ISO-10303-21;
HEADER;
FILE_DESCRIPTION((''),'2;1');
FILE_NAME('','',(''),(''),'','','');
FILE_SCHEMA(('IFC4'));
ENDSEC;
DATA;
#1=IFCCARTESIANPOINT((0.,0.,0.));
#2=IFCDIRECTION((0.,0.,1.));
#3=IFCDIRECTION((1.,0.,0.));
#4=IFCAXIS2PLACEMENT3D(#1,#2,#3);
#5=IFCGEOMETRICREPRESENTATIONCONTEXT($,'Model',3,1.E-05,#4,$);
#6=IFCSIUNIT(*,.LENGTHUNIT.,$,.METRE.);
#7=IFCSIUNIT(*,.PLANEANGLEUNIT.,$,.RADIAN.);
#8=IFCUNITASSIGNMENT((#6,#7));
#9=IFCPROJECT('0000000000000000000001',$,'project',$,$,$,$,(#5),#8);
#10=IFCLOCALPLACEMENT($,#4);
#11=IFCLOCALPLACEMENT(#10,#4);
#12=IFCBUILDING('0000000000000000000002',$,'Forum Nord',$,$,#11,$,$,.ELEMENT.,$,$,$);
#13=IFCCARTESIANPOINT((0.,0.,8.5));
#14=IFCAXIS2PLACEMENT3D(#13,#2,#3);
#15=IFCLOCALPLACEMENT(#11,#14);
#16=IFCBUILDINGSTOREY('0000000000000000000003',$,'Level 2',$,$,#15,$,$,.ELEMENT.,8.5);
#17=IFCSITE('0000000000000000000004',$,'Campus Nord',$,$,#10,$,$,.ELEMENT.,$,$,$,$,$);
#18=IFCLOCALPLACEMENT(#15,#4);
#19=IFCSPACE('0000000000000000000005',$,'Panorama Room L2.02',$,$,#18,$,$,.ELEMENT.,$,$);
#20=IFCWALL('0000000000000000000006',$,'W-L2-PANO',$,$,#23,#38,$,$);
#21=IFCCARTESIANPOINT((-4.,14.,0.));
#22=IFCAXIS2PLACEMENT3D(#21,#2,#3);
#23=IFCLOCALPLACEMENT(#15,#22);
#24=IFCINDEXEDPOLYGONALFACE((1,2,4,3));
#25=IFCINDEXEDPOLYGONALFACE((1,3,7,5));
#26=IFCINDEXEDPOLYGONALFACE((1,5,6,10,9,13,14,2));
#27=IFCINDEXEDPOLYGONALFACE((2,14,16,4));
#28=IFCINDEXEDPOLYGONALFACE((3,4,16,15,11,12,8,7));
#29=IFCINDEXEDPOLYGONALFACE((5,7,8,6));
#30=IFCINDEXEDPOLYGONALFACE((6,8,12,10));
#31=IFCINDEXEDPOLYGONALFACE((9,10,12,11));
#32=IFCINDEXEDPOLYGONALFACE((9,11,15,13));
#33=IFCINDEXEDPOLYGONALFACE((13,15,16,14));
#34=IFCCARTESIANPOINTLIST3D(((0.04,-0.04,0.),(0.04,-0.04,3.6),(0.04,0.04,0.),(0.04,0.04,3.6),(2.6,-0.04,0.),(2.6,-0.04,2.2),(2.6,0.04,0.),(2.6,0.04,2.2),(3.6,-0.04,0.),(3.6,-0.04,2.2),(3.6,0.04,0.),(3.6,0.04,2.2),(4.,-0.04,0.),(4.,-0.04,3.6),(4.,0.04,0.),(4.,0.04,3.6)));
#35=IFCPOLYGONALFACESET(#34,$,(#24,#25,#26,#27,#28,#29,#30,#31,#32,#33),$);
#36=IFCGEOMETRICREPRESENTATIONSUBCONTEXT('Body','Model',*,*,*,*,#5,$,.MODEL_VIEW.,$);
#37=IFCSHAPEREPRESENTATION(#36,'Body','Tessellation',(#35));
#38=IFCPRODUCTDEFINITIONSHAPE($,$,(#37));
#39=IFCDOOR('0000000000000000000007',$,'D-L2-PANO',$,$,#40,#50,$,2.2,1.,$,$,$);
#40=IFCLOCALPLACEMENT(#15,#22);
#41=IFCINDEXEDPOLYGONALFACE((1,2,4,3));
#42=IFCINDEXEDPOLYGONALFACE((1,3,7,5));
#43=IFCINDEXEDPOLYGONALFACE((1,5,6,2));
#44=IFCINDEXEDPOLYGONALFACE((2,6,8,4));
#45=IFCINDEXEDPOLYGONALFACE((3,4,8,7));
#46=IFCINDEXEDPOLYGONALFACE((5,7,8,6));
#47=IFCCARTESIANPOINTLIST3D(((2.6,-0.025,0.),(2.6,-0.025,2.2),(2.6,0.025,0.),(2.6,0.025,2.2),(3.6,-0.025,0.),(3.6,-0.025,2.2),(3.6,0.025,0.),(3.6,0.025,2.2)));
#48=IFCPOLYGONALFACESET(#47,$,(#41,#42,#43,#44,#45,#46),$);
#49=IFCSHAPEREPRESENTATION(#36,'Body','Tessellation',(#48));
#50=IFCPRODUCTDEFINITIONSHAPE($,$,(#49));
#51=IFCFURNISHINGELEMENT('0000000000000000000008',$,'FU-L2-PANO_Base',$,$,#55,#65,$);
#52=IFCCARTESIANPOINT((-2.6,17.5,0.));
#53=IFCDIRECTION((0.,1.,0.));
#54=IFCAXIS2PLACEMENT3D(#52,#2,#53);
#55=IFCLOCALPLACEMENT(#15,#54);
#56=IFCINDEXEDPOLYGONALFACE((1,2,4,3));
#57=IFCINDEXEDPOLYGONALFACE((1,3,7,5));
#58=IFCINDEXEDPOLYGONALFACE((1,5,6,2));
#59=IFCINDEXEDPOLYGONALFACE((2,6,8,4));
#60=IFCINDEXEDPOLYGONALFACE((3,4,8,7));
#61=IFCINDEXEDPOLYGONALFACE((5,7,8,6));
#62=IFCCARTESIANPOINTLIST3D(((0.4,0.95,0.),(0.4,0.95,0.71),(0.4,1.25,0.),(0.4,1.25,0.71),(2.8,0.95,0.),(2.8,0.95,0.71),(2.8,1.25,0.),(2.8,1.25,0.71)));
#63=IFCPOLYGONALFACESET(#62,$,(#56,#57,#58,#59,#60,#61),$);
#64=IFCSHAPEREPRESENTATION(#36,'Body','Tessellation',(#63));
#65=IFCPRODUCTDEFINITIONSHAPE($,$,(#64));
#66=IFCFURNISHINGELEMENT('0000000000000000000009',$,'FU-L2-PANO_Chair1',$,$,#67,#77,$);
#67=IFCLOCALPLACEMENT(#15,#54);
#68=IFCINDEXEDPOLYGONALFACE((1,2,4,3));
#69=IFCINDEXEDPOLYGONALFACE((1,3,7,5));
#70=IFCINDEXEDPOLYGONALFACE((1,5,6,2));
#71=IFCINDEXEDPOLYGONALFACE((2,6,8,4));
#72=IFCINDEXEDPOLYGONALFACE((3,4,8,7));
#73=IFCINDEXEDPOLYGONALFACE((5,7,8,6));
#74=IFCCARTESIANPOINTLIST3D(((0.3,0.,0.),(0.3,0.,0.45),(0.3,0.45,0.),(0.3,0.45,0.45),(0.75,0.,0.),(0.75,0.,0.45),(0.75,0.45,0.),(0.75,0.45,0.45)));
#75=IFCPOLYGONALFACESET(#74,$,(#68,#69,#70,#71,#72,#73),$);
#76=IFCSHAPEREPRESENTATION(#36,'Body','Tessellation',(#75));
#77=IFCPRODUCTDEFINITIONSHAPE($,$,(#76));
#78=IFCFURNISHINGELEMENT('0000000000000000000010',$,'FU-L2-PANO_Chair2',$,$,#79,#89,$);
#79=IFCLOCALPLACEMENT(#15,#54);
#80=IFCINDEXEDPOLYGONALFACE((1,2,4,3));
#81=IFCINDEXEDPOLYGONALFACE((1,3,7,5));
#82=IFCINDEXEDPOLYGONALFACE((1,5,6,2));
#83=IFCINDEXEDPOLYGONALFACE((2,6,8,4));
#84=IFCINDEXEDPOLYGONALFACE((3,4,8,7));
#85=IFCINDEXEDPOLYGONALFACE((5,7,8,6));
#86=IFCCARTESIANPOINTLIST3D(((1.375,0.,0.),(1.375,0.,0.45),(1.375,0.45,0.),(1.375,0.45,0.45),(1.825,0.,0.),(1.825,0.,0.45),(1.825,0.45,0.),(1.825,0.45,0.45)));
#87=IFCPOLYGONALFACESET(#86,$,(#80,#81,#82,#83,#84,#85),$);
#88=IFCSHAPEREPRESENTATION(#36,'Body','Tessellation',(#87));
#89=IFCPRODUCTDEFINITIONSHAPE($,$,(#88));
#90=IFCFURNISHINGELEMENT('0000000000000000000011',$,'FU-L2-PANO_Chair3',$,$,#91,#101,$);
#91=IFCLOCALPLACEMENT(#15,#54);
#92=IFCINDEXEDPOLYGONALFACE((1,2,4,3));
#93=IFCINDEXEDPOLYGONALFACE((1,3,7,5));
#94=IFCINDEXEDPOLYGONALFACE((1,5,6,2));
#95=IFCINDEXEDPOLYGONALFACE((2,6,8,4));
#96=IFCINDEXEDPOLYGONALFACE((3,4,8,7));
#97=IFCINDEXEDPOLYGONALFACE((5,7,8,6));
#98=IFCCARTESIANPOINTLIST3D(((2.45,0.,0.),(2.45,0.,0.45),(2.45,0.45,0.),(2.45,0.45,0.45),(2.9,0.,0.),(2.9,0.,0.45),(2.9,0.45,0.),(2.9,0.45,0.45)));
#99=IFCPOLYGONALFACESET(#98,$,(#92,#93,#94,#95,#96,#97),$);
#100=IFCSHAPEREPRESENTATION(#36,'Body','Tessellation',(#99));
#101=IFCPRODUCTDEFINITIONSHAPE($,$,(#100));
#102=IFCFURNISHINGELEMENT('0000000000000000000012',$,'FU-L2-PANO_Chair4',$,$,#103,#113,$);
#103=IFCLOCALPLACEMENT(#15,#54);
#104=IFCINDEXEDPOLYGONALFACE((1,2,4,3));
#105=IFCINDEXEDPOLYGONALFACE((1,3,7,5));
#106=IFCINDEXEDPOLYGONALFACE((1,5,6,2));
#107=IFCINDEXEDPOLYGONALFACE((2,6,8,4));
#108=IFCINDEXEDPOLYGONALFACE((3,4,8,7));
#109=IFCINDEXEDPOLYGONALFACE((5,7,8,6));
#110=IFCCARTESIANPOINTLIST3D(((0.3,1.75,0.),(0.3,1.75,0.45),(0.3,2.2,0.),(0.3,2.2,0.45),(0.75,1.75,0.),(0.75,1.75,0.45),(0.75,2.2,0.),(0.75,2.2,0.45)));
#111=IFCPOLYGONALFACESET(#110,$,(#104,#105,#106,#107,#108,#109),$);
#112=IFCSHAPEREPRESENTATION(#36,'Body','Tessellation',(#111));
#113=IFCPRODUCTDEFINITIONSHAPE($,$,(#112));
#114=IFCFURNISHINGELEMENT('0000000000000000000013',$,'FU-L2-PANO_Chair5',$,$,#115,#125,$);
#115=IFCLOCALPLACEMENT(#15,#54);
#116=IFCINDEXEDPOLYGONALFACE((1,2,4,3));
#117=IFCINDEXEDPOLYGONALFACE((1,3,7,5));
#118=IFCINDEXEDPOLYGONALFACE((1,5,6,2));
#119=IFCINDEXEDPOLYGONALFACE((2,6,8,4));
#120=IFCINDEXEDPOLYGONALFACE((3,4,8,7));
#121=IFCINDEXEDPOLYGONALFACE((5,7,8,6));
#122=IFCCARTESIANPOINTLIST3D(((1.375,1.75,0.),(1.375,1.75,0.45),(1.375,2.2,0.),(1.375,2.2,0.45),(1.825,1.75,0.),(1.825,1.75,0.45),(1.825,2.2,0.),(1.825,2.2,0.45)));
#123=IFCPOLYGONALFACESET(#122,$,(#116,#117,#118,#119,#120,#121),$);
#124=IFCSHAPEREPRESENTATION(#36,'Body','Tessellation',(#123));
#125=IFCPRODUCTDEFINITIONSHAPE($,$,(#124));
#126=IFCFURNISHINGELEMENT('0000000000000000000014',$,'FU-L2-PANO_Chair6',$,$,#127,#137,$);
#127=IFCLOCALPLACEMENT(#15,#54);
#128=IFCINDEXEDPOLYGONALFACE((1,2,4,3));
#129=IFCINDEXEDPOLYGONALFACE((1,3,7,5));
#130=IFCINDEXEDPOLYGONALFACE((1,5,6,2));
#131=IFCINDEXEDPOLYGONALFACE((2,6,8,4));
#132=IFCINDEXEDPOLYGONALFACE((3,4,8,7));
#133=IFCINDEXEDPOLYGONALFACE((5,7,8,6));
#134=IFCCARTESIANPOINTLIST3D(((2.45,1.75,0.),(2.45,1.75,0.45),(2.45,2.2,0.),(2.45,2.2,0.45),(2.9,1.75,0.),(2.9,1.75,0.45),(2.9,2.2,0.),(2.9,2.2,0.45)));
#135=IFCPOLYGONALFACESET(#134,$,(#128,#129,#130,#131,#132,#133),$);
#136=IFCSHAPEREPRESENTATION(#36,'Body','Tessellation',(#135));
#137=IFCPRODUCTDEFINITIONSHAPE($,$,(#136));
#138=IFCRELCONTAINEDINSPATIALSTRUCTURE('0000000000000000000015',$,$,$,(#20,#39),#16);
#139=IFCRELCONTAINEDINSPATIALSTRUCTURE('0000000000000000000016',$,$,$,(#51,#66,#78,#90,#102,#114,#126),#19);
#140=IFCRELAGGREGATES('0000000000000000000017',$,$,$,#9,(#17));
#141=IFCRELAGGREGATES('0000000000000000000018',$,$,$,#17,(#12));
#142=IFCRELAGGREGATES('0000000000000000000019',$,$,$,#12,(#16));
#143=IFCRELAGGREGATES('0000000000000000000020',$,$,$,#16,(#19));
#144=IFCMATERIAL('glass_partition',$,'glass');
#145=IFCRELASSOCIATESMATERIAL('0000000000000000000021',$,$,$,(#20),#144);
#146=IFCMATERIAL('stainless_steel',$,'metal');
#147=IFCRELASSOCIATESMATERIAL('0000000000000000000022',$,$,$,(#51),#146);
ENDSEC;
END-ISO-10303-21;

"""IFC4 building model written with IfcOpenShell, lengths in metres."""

from ifc_helpers import new_model, si_unit, frame, frame_2d, origin_with_axes, place, context, subcontext, project, spatial, polyline, rectangle, outline, extrude, material, element, fill, save


model = new_model("IFC4")

# Units and contexts
model_context = context("Model", 3, precision=1e-05, world=origin_with_axes())
body_context = subcontext(model_context, "Body", "Model", "MODEL_VIEW")
ifc_project = project(units=[si_unit("LENGTHUNIT", "METRE"), si_unit("PLANEANGLEUNIT", "RADIAN")], contexts=[model_context])

# Site, building, storey
site_placement = place(None, origin_with_axes())
site = spatial("IfcSite", under=ifc_project, at=site_placement, Name="Campus Nord", CompositionType="ELEMENT")
building_placement = place(site_placement, origin_with_axes())
building = spatial("IfcBuilding", under=site, at=building_placement, Name="Forum Nord", CompositionType="ELEMENT")
storey_placement = place(building_placement, frame((0.0, 0.0, 8.5), z_axis=(0.0, 0.0, 1.0), x_axis=(1.0, 0.0, 0.0)))
storey = spatial("IfcBuildingStorey", under=building, at=storey_placement, Name="Level 2", CompositionType="ELEMENT", Elevation=8.5)

# Wall, opening, door
ifc_material_1 = material(Name="glass_partition", Category="glass")
wall_1_placement = place(storey_placement, frame((-4.0, 14.0, 0.0), z_axis=(0.0, 0.0, 1.0), x_axis=(1.0, 0.0, 0.0)))
wall_1 = element("IfcWall", 1, at=wall_1_placement, inside=storey, material=ifc_material_1, Name="W-L2-PANO", context=body_context, shape_type="SweptSolid", body=[
    extrude(outline(polyline([(0.04, -0.04), (4.0, -0.04), (4.0, 0.04), (0.04, 0.04), (0.04, -0.04)])), origin_with_axes(), (0.0, 0.0, 1.0), 3.6),
])
opening_placement = place(storey_placement, frame((-4.0, 14.0, 0.0), z_axis=(0.0, 0.0, 1.0), x_axis=(1.0, 0.0, 0.0)))
opening = element("IfcOpeningElement", 2, at=opening_placement, cuts=wall_1, context=body_context, shape_type="SweptSolid", body=[
    extrude(rectangle(XDim=1.0, YDim=0.08, at=frame_2d((3.1, 0.0), x_axis=(1.0, 0.0))), origin_with_axes(), (0.0, 0.0, 1.0), 2.2),
])
door_placement = place(storey_placement, frame((-4.0, 14.0, 0.0), z_axis=(0.0, 0.0, 1.0), x_axis=(1.0, 0.0, 0.0)))
door = element("IfcDoor", 3, at=door_placement, inside=storey, Name="D-L2-PANO", OverallHeight=2.2, OverallWidth=1.0, context=body_context, shape_type="SweptSolid", body=[
    extrude(rectangle(XDim=1.0, YDim=0.05, at=frame_2d((3.1, 0.0), x_axis=(1.0, 0.0))), origin_with_axes(), (0.0, 0.0, 1.0), 2.2),
])
fill(opening, door)

# Shared definitions
space_placement = place(storey_placement, origin_with_axes())
space = spatial("IfcSpace", under=storey, at=space_placement, Name="Panorama Room L2.02", CompositionType="ELEMENT")

# Furnishing elements
ifc_material_2 = material(Name="stainless_steel", Category="metal")
furnishing_1_placement = place(storey_placement, frame((-2.6, 17.5, 0.0), z_axis=(0.0, 0.0, 1.0), x_axis=(0.0, 1.0, 0.0)))
element("IfcFurnishingElement", 4, at=furnishing_1_placement, inside=space, material=ifc_material_2, Name="FU-L2-PANO_Base", context=body_context, shape_type="SweptSolid", body=[
    extrude(rectangle(XDim=2.4, YDim=0.3, at=frame_2d((1.6, 1.1), x_axis=(1.0, 0.0))), origin_with_axes(), (0.0, 0.0, 1.0), 0.71),
])
furnishing_2_placement = place(storey_placement, frame((-2.6, 17.5, 0.0), z_axis=(0.0, 0.0, 1.0), x_axis=(0.0, 1.0, 0.0)))
element("IfcFurnishingElement", 5, at=furnishing_2_placement, inside=space, Name="FU-L2-PANO_Chair1", context=body_context, shape_type="SweptSolid", body=[
    extrude(rectangle(XDim=0.45, YDim=0.45, at=frame_2d((0.525, 0.225), x_axis=(1.0, 0.0))), origin_with_axes(), (0.0, 0.0, 1.0), 0.45),
])
furnishing_3_placement = place(storey_placement, frame((-2.6, 17.5, 0.0), z_axis=(0.0, 0.0, 1.0), x_axis=(0.0, 1.0, 0.0)))
element("IfcFurnishingElement", 6, at=furnishing_3_placement, inside=space, Name="FU-L2-PANO_Chair2", context=body_context, shape_type="SweptSolid", body=[
    extrude(rectangle(XDim=0.45, YDim=0.45, at=frame_2d((1.6, 0.225), x_axis=(1.0, 0.0))), origin_with_axes(), (0.0, 0.0, 1.0), 0.45),
])
furnishing_4_placement = place(storey_placement, frame((-2.6, 17.5, 0.0), z_axis=(0.0, 0.0, 1.0), x_axis=(0.0, 1.0, 0.0)))
element("IfcFurnishingElement", 7, at=furnishing_4_placement, inside=space, Name="FU-L2-PANO_Chair3", context=body_context, shape_type="SweptSolid", body=[
    extrude(rectangle(XDim=0.45, YDim=0.45, at=frame_2d((2.675, 0.225), x_axis=(1.0, 0.0))), origin_with_axes(), (0.0, 0.0, 1.0), 0.45),
])
furnishing_5_placement = place(storey_placement, frame((-2.6, 17.5, 0.0), z_axis=(0.0, 0.0, 1.0), x_axis=(0.0, 1.0, 0.0)))
element("IfcFurnishingElement", 8, at=furnishing_5_placement, inside=space, Name="FU-L2-PANO_Chair4", context=body_context, shape_type="SweptSolid", body=[
    extrude(rectangle(XDim=0.45, YDim=0.45, at=frame_2d((0.525, 1.975), x_axis=(1.0, 0.0))), origin_with_axes(), (0.0, 0.0, 1.0), 0.45),
])
furnishing_6_placement = place(storey_placement, frame((-2.6, 17.5, 0.0), z_axis=(0.0, 0.0, 1.0), x_axis=(0.0, 1.0, 0.0)))
element("IfcFurnishingElement", 9, at=furnishing_6_placement, inside=space, Name="FU-L2-PANO_Chair5", context=body_context, shape_type="SweptSolid", body=[
    extrude(rectangle(XDim=0.45, YDim=0.45, at=frame_2d((1.6, 1.975), x_axis=(1.0, 0.0))), origin_with_axes(), (0.0, 0.0, 1.0), 0.45),
])
furnishing_7_placement = place(storey_placement, frame((-2.6, 17.5, 0.0), z_axis=(0.0, 0.0, 1.0), x_axis=(0.0, 1.0, 0.0)))
element("IfcFurnishingElement", 10, at=furnishing_7_placement, inside=space, Name="FU-L2-PANO_Chair6", context=body_context, shape_type="SweptSolid", body=[
    extrude(rectangle(XDim=0.45, YDim=0.45, at=frame_2d((2.675, 1.975), x_axis=(1.0, 0.0))), origin_with_axes(), (0.0, 0.0, 1.0), 0.45),
])

save(model, "model.ifc")
